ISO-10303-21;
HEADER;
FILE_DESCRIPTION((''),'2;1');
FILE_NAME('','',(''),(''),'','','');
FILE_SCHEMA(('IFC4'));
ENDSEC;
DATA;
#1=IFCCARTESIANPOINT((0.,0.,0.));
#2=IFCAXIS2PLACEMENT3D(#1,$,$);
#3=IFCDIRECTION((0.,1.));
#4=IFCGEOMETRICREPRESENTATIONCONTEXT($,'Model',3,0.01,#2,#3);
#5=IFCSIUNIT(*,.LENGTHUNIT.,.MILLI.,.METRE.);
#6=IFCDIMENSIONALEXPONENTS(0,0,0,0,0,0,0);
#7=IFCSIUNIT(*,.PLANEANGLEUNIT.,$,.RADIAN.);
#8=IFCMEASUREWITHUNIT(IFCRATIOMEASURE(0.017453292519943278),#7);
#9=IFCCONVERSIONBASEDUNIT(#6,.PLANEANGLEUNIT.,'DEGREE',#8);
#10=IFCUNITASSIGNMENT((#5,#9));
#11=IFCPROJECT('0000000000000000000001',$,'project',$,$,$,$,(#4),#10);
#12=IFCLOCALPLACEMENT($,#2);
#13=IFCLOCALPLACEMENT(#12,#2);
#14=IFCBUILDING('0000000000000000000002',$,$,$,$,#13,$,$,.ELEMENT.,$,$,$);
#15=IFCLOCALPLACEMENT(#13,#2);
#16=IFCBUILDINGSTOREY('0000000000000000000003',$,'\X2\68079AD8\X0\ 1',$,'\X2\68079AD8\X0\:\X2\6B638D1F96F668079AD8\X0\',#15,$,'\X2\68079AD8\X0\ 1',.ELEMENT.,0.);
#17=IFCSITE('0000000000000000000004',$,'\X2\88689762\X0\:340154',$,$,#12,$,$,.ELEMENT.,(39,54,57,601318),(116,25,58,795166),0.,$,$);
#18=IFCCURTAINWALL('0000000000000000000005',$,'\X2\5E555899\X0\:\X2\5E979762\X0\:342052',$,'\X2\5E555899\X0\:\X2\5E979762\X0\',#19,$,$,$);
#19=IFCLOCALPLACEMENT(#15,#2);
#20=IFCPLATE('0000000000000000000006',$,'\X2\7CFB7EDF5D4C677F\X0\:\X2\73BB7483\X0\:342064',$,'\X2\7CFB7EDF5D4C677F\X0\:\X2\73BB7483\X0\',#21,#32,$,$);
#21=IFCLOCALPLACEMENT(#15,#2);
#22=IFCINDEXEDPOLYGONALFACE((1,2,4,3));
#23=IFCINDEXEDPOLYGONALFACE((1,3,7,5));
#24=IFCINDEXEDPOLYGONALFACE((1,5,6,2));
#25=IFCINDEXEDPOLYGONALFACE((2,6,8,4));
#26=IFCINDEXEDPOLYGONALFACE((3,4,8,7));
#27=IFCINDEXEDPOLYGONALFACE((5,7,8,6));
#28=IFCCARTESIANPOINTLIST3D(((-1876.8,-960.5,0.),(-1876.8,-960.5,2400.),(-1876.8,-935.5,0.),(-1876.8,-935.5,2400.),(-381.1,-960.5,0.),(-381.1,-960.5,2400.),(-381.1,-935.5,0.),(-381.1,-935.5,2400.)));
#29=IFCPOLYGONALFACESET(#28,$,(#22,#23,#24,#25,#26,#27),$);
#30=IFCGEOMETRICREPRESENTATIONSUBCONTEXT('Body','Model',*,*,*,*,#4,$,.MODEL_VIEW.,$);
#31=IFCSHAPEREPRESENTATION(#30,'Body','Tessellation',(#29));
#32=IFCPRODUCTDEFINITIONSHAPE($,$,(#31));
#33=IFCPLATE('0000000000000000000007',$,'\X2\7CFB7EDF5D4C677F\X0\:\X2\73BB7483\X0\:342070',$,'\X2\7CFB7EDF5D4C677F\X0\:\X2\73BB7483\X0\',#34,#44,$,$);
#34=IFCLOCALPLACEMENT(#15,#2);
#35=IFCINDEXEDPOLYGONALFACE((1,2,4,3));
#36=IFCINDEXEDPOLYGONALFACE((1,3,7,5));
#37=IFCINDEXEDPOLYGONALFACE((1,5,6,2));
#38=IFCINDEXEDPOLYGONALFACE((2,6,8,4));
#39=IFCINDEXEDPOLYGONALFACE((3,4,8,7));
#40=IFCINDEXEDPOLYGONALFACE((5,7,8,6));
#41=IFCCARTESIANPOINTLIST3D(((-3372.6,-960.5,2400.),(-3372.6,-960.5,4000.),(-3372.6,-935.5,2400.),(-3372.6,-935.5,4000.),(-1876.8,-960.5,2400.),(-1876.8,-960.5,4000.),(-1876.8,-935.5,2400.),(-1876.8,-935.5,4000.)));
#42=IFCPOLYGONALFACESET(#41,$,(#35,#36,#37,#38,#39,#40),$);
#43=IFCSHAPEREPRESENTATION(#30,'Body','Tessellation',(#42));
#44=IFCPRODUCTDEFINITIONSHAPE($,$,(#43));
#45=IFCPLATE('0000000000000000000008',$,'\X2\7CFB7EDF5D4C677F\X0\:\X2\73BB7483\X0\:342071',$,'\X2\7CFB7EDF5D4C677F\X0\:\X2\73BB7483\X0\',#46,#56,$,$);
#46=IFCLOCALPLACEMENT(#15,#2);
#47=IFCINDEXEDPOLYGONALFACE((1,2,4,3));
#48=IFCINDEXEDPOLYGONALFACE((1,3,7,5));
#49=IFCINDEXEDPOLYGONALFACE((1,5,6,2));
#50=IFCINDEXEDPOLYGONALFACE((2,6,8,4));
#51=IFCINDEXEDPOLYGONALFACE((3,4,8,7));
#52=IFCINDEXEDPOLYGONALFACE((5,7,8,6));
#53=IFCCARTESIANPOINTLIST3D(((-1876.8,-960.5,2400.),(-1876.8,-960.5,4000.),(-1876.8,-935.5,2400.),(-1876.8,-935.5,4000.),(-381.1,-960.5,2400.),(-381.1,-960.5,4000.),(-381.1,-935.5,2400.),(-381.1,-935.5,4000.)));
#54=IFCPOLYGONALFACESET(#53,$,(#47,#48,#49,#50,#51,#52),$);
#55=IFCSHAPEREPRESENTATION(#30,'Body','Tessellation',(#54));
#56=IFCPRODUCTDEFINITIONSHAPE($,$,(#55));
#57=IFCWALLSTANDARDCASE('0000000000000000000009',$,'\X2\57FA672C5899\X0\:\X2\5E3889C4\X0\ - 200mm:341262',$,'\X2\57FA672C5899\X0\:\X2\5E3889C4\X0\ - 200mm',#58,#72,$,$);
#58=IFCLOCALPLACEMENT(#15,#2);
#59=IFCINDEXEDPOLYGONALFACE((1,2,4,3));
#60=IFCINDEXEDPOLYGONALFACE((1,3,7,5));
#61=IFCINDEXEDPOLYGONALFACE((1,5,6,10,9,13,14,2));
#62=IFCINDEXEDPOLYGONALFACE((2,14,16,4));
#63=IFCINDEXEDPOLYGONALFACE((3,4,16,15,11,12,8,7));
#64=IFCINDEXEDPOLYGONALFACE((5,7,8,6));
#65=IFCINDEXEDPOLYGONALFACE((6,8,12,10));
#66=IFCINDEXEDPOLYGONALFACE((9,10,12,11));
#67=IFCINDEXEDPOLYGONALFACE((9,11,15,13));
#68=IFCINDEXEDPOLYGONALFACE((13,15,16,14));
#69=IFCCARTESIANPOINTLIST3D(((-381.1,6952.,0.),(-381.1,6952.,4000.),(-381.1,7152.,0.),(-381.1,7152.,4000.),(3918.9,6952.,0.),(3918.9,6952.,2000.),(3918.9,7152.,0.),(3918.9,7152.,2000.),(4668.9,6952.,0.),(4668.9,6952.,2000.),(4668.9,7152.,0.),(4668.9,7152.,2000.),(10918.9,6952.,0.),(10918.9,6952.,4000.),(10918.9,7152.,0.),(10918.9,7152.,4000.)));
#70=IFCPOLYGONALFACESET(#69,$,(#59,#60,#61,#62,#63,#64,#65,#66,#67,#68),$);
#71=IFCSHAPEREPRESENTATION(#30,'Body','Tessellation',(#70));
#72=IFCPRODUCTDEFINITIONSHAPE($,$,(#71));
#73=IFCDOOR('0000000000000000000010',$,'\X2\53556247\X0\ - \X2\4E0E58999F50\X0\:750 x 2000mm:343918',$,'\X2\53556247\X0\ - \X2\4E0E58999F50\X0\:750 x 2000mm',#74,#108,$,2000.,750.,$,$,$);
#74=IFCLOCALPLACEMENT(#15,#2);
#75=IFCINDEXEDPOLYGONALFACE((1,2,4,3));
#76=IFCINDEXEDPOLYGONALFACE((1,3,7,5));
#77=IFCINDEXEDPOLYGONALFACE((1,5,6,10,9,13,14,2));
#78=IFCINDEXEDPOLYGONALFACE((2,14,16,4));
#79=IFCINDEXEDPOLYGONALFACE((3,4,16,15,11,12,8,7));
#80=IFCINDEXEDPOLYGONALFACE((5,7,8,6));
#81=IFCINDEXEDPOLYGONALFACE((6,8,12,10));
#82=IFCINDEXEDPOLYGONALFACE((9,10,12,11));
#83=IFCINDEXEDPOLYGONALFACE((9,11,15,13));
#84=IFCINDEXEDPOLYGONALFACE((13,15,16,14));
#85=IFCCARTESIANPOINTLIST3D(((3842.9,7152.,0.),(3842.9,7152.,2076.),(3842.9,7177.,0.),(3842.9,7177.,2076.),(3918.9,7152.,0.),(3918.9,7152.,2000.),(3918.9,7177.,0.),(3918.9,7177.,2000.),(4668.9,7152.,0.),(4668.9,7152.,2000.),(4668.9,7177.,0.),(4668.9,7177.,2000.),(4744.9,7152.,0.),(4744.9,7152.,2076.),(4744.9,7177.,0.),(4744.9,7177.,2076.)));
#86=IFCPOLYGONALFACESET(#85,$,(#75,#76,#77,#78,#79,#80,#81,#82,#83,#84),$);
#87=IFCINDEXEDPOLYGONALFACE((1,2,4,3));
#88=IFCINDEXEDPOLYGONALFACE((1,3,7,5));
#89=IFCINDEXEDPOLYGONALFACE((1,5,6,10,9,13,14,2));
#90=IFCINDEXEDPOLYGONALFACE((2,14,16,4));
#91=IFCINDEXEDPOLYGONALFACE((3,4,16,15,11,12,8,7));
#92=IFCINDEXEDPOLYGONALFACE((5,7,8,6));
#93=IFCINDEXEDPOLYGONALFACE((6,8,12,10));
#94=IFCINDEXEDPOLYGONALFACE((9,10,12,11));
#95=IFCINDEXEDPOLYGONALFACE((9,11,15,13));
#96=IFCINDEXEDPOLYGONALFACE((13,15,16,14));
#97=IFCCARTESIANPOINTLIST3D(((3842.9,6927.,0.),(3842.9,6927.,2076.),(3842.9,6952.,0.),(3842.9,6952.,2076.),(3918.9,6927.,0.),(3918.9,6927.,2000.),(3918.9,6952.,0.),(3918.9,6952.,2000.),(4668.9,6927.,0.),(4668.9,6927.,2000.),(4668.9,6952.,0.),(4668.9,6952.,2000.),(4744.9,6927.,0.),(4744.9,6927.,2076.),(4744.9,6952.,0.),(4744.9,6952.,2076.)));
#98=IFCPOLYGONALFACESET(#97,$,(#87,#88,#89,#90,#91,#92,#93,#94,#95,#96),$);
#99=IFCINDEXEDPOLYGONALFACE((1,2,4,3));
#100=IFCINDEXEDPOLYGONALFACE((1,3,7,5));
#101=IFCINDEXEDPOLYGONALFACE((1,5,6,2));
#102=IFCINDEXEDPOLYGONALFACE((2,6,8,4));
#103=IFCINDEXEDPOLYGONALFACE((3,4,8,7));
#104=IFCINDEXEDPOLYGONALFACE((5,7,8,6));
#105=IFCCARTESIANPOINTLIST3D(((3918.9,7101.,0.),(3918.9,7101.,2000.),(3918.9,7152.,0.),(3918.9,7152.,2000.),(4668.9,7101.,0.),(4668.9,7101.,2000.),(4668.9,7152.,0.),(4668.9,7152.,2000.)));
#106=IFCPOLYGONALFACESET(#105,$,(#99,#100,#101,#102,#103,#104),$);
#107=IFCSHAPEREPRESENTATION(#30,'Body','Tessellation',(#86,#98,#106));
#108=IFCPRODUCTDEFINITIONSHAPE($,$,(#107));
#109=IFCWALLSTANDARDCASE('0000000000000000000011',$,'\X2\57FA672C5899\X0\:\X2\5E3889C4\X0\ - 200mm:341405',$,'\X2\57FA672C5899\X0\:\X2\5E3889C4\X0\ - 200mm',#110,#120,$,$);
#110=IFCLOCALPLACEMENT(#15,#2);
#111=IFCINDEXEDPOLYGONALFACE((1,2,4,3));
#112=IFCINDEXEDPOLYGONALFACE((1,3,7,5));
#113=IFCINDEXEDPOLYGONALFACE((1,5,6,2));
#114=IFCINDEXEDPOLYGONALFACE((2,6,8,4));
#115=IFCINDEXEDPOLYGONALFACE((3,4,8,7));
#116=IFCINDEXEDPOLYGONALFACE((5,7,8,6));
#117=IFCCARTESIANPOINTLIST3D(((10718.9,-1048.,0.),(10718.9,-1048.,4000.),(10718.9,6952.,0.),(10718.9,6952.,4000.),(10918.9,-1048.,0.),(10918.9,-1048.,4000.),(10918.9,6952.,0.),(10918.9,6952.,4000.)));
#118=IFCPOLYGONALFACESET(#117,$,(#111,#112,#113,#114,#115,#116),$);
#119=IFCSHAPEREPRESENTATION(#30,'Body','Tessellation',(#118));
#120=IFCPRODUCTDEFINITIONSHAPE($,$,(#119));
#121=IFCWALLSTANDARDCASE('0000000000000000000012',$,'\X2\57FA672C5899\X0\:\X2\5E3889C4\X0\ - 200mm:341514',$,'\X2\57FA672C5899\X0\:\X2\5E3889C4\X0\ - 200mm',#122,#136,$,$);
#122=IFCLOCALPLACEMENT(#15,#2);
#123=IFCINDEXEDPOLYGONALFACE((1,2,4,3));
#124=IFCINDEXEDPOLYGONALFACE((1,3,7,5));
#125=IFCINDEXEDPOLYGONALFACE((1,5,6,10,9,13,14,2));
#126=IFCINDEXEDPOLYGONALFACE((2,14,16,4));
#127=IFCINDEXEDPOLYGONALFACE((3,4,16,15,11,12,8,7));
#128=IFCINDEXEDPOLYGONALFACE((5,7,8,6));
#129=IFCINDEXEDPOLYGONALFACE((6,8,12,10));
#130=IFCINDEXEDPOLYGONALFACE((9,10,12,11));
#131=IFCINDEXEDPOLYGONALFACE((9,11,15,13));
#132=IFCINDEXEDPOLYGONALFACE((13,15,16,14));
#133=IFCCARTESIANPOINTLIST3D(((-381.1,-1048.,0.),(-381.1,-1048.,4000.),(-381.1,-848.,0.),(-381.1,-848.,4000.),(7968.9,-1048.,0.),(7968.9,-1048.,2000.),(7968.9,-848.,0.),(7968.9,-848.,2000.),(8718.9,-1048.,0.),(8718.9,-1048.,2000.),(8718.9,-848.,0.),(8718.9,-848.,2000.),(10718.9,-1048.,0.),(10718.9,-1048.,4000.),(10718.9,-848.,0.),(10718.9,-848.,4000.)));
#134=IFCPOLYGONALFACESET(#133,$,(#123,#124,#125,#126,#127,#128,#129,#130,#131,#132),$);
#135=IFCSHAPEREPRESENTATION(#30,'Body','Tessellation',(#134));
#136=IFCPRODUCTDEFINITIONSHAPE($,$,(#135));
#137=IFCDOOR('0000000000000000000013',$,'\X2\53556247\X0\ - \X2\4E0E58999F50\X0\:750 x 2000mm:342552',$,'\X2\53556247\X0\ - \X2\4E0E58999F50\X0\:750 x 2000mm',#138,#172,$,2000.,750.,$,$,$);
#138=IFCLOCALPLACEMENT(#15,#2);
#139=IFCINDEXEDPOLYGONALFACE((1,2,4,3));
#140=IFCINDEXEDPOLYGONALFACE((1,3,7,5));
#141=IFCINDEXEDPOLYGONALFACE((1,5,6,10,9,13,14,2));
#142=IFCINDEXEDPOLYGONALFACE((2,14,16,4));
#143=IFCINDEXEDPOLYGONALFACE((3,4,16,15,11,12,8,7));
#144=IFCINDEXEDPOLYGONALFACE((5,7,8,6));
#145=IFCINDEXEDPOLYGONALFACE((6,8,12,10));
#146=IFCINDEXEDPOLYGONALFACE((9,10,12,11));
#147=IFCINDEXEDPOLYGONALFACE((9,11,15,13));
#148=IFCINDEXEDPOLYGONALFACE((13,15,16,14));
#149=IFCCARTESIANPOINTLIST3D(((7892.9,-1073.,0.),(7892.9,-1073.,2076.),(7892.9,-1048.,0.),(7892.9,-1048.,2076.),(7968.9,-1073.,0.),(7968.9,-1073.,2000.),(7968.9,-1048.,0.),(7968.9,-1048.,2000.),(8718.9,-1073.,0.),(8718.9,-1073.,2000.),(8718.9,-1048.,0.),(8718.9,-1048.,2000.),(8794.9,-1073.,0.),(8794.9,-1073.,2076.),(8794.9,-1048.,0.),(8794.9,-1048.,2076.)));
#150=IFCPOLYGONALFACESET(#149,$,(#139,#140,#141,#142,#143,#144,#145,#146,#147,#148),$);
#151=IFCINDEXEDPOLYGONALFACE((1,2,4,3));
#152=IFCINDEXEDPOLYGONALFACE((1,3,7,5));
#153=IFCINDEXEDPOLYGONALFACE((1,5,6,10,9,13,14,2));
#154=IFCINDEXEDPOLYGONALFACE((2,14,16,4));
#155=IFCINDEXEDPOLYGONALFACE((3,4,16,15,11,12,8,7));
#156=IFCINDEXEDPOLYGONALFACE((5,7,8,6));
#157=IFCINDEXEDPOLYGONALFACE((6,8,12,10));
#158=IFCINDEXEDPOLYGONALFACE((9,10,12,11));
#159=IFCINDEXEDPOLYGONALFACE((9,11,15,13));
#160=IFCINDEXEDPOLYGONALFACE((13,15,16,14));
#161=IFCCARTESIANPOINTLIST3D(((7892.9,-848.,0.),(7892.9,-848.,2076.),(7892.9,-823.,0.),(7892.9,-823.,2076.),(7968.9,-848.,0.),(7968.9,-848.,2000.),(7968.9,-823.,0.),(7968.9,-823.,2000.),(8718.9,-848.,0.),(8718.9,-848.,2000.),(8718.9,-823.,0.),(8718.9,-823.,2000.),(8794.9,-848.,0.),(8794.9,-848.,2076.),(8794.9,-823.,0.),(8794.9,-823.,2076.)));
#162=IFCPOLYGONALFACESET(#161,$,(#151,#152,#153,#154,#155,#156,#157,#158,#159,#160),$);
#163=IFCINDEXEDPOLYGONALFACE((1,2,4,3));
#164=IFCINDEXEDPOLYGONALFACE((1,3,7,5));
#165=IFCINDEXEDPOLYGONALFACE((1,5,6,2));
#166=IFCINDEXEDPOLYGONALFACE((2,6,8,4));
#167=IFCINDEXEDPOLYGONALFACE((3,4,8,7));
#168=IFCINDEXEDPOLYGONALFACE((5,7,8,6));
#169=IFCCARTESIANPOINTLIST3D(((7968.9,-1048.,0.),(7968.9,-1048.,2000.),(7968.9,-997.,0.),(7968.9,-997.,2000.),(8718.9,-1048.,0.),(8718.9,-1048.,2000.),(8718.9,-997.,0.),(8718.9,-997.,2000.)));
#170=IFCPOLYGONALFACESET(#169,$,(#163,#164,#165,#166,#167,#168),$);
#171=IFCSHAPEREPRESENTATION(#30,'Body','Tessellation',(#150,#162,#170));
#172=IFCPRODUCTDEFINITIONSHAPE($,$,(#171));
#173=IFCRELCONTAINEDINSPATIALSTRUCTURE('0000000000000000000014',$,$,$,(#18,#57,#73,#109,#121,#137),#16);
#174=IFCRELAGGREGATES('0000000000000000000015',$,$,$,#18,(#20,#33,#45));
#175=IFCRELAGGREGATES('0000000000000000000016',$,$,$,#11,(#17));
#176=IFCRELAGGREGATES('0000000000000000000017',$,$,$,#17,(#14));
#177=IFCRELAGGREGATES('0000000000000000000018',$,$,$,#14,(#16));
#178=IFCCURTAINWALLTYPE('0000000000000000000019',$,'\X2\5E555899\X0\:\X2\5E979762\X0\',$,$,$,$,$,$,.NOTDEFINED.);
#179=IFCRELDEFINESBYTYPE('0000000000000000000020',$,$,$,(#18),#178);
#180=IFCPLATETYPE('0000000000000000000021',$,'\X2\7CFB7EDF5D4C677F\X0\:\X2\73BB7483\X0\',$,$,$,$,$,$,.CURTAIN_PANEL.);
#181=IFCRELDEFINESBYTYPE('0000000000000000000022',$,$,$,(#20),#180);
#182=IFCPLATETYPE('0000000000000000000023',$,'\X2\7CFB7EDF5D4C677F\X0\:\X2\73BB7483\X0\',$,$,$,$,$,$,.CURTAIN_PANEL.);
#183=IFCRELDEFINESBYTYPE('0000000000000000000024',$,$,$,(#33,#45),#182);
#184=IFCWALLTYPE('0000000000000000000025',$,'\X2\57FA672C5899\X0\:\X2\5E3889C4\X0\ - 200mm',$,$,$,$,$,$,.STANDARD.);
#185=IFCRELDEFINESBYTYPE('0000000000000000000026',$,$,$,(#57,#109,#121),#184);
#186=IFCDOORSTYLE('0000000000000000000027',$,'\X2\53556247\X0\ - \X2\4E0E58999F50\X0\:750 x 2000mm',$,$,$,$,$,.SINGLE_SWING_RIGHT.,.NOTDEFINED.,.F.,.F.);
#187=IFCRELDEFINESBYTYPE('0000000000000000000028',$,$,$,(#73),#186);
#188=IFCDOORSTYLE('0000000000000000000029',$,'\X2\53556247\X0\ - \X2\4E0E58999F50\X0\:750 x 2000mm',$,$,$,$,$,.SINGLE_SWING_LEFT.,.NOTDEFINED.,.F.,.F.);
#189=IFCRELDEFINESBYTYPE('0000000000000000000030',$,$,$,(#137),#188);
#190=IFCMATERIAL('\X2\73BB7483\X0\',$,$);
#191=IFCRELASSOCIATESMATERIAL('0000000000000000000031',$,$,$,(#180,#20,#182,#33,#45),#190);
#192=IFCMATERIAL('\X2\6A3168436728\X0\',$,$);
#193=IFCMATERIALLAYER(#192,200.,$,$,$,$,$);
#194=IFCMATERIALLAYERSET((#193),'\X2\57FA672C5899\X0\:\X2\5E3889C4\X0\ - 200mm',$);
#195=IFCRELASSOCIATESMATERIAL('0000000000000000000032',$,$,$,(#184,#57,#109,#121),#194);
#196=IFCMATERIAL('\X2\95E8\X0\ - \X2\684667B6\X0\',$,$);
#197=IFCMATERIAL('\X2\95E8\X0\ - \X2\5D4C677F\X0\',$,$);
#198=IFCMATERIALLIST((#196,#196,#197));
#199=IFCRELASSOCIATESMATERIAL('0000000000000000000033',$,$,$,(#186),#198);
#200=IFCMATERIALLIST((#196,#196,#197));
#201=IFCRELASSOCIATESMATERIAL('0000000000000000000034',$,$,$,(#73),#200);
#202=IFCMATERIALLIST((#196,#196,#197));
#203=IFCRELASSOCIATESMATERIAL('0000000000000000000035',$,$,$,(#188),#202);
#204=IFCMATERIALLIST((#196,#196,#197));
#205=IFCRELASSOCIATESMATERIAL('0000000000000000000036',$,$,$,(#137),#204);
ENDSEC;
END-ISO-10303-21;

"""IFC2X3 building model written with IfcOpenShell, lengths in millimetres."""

from ifc_helpers import new_model, entity, si_unit, converted_unit, direction, frame, frame_2d, origin, origin_2d_with_axis, place, context, subcontext, project, spatial, polyline, rectangle, outline, extrude, source, transform, mapped, material, material_list, layer, layer_set, layer_usage, type_object, type_shapes, element, fill, aggregate, save


model = new_model("IFC2X3")

# Units and contexts
model_context = context("Model", 3, precision=0.01, world=origin(), true_north=direction((0.0, 1.0)))
body_context = subcontext(model_context, "Body", "Model", "MODEL_VIEW")
ifc_project = project(units=[si_unit("LENGTHUNIT", "METRE", prefix="MILLI"), converted_unit("PLANEANGLEUNIT", "DEGREE", entity("IfcRatioMeasure", 0.017453292519943278), si_unit("PLANEANGLEUNIT", "RADIAN"), dimensions=[0, 0, 0, 0, 0, 0, 0])], contexts=[model_context])

# Site, building, storey
site_placement = place(None, origin())
site = spatial("IfcSite", under=ifc_project, at=site_placement, Name="表面:340154", CompositionType="ELEMENT", RefLatitude=(39, 54, 57, 601318), RefLongitude=(116, 25, 58, 795166), RefElevation=0.0)
building_placement = place(site_placement, origin())
building = spatial("IfcBuilding", under=site, at=building_placement, CompositionType="ELEMENT")
storey_placement = place(building_placement, origin())
storey = spatial("IfcBuildingStorey", under=building, at=storey_placement, Name="标高 1", ObjectType="标高:正负零标高", LongName="标高 1", CompositionType="ELEMENT", Elevation=0.0)

# Shared definitions
curtain_wall_type = type_object("IfcCurtainWallType", Name="幕墙:店面", PredefinedType="NOTDEFINED")
ifc_material_1 = material(Name="玻璃")

# Curtain wall, plates
curtain_wall_1_placement = place(storey_placement, origin())
curtain_wall_1 = element("IfcCurtainWall", 1, at=curtain_wall_1_placement, inside=storey, type_object=curtain_wall_type, Name="幕墙:店面:342052", ObjectType="幕墙:店面")
plate_type_1 = type_object("IfcPlateType", Name="系统嵌板:玻璃", PredefinedType="CURTAIN_PANEL", material=ifc_material_1)
shared_shape_1 = source(origin(), body_context, "Body", "SweptSolid", [
    extrude(rectangle(XDim=25.0, YDim=1495.8, at=origin_2d_with_axis()), frame((0.0, 0.0, 0.0), z_axis=(0.0, 0.0, 1.0), x_axis=(0.0, 1.0, 0.0)), (0.0, 0.0, 1.0), 2400.0),
])
type_shapes(plate_type_1, [shared_shape_1])
plate_1_placement = place(curtain_wall_1_placement, frame((-1129.0, -948.0, 0.0)))
plate_1 = element("IfcPlate", 2, at=plate_1_placement, type_object=plate_type_1, material=ifc_material_1, Name="系统嵌板:玻璃:342064", ObjectType="系统嵌板:玻璃", context=body_context, shape_type="MappedRepresentation", body=[
    mapped(shared_shape_1, transform((0.0, 0.0, 0.0), scale=1.0)),
])
plate_type_2 = type_object("IfcPlateType", Name="系统嵌板:玻璃", PredefinedType="CURTAIN_PANEL", material=ifc_material_1)
shared_shape_2 = source(origin(), body_context, "Body", "SweptSolid", [
    extrude(rectangle(XDim=25.0, YDim=1495.8, at=origin_2d_with_axis()), frame((0.0, 0.0, 0.0), z_axis=(0.0, 0.0, 1.0), x_axis=(0.0, 1.0, 0.0)), (0.0, 0.0, 1.0), 1600.0),
])
type_shapes(plate_type_2, [shared_shape_2])
plate_2_placement = place(curtain_wall_1_placement, frame((-2624.7, -948.0, 2400.0)))
plate_2 = element("IfcPlate", 3, at=plate_2_placement, type_object=plate_type_2, material=ifc_material_1, Name="系统嵌板:玻璃:342070", ObjectType="系统嵌板:玻璃", context=body_context, shape_type="MappedRepresentation", body=[
    mapped(shared_shape_2, transform((0.0, 0.0, 0.0), scale=1.0)),
])
plate_3_placement = place(curtain_wall_1_placement, frame((-1129.0, -948.0, 2400.0)))
plate_3 = element("IfcPlate", 4, at=plate_3_placement, type_object=plate_type_2, material=ifc_material_1, Name="系统嵌板:玻璃:342071", ObjectType="系统嵌板:玻璃", context=body_context, shape_type="MappedRepresentation", body=[
    mapped(shared_shape_2, transform((0.0, 0.0, 0.0), scale=1.0)),
])
aggregate(curtain_wall_1, [plate_1, plate_2, plate_3])

# Wall, opening, door
ifc_material_2 = material(Name="樱桃木")
ifc_layer_1 = layer(ifc_material_2, 200.0)
ifc_layer_set_1 = layer_set([ifc_layer_1], Name="基本墙:常规 - 200mm")
ifc_layer_usage_1 = layer_usage(ifc_layer_set_1, "AXIS2", "NEGATIVE", 100.0)
wall_type_1 = type_object("IfcWallType", Name="基本墙:常规 - 200mm", PredefinedType="STANDARD", material=ifc_layer_set_1)
wall_1_placement = place(storey_placement, frame((-381.1, 7052.0, 0.0)))
wall_1 = element("IfcWallStandardCase", 5, at=wall_1_placement, inside=storey, type_object=wall_type_1, material=ifc_layer_usage_1, Name="基本墙:常规 - 200mm:341262", ObjectType="基本墙:常规 - 200mm", context=body_context, shape_type="SweptSolid", body=[
    extrude(rectangle(XDim=11300.0, YDim=200.0, at=frame_2d((5650.0, 0.0), x_axis=(1.0, 0.0))), origin(), (0.0, 0.0, 1.0), 4000.0),
])
opening_1_placement = place(wall_1_placement, frame((4300.0, -100.0, 0.0)))
opening_1 = element("IfcOpeningElement", 6, at=opening_1_placement, cuts=wall_1, ObjectType="Opening", context=body_context, shape_type="SweptSolid", body=[
    extrude(rectangle(XDim=750.0, YDim=2000.0, at=frame_2d((1000.0, 375.0), x_axis=(0.0, 1.0))), frame((0.0, 0.0, 0.0), z_axis=(0.0, 1.0, 0.0), x_axis=(0.0, 0.0, 1.0)), (0.0, 0.0, 1.0), 200.0),
])
ifc_material_3 = material(Name="门 - 框架")
ifc_material_4 = material(Name="门 - 嵌板")
ifc_material_list_1 = material_list([ifc_material_3, ifc_material_3, ifc_material_4])
ifc_material_list_2 = material_list([ifc_material_3, ifc_material_3, ifc_material_4])
door_style_1 = type_object("IfcDoorStyle", Name="单扇 - 与墙齐:750 x 2000mm", ConstructionType="NOTDEFINED", OperationType="SINGLE_SWING_RIGHT", ParameterTakesPrecedence=False, Sizeable=False, material=ifc_material_list_2)
shared_shape_3 = source(origin(), body_context, "Body", "SweptSolid", [
    extrude(outline(polyline([(-451.0, -1057.0), (451.0, -1057.0), (451.0, 1019.0), (375.0, 1019.0), (375.0, -981.0), (-375.0, -981.0), (-375.0, 1019.0), (-451.0, 1019.0), (-451.0, -1057.0)])), frame((375.0, 200.0, 1019.0), z_axis=(0.0, 1.0, 0.0), x_axis=(1.0, 0.0, 0.0)), (0.0, 0.0, 1.0), 25.0),
    extrude(outline(polyline([(-1057.0, -451.0), (1019.0, -451.0), (1019.0, -375.0), (-981.0, -375.0), (-981.0, 375.0), (1019.0, 375.0), (1019.0, 451.0), (-1057.0, 451.0), (-1057.0, -451.0)])), frame((375.0, -25.0, 1019.0), z_axis=(0.0, 1.0, 0.0), x_axis=(0.0, 0.0, -1.0)), (0.0, 0.0, 1.0), 25.0),
    extrude(rectangle(XDim=51.0, YDim=750.0, at=frame_2d((0.0, 0.0), x_axis=(1.0, 0.0))), frame((375.0, 174.5, 0.0), z_axis=(0.0, 0.0, 1.0), x_axis=(0.0, 1.0, 0.0)), (0.0, 0.0, 1.0), 2000.0),
])
type_shapes(door_style_1, [shared_shape_3])
door_1_placement = place(opening_1_placement, origin())
door_1 = element("IfcDoor", 7, at=door_1_placement, inside=storey, type_object=door_style_1, material=ifc_material_list_1, Name="单扇 - 与墙齐:750 x 2000mm:343918", ObjectType="单扇 - 与墙齐:750 x 2000mm", OverallHeight=2000.0, OverallWidth=750.0, context=body_context, shape_type="MappedRepresentation", body=[
    mapped(shared_shape_3, transform((0.0, 0.0, 0.0), scale=1.0)),
])
fill(opening_1, door_1)

# Wall
ifc_layer_usage_2 = layer_usage(ifc_layer_set_1, "AXIS2", "NEGATIVE", 100.0)
wall_2_placement = place(storey_placement, frame((10818.9, 6952.0, 0.0), z_axis=(0.0, 0.0, 1.0), x_axis=(0.0, -1.0, 0.0)))
element("IfcWallStandardCase", 8, at=wall_2_placement, inside=storey, type_object=wall_type_1, material=ifc_layer_usage_2, Name="基本墙:常规 - 200mm:341405", ObjectType="基本墙:常规 - 200mm", context=body_context, shape_type="SweptSolid", body=[
    extrude(rectangle(XDim=8000.0, YDim=200.0, at=frame_2d((4000.0, 0.0), x_axis=(-1.0, 0.0))), origin(), (0.0, 0.0, 1.0), 4000.0),
])

# Wall, opening, door
ifc_layer_usage_3 = layer_usage(ifc_layer_set_1, "AXIS2", "NEGATIVE", 100.0)
wall_3_placement = place(storey_placement, frame((10718.9, -948.0, 0.0), z_axis=(0.0, 0.0, 1.0), x_axis=(-1.0, 0.0, 0.0)))
wall_3 = element("IfcWallStandardCase", 9, at=wall_3_placement, inside=storey, type_object=wall_type_1, material=ifc_layer_usage_3, Name="基本墙:常规 - 200mm:341514", ObjectType="基本墙:常规 - 200mm", context=body_context, shape_type="SweptSolid", body=[
    extrude(rectangle(XDim=11100.0, YDim=200.0, at=frame_2d((5550.0, 0.0), x_axis=(1.0, 0.0))), origin(), (0.0, 0.0, 1.0), 4000.0),
])
opening_2_placement = place(wall_3_placement, frame((2000.0, -100.0, 0.0)))
opening_2 = element("IfcOpeningElement", 10, at=opening_2_placement, cuts=wall_3, ObjectType="Opening", context=body_context, shape_type="SweptSolid", body=[
    extrude(rectangle(XDim=750.0, YDim=2000.0, at=frame_2d((1000.0, 375.0), x_axis=(0.0, -1.0))), frame((0.0, 0.0, 0.0), z_axis=(0.0, 1.0, 0.0), x_axis=(0.0, 0.0, 1.0)), (0.0, 0.0, 1.0), 200.0),
])
ifc_material_list_3 = material_list([ifc_material_3, ifc_material_3, ifc_material_4])
ifc_material_list_4 = material_list([ifc_material_3, ifc_material_3, ifc_material_4])
door_style_2 = type_object("IfcDoorStyle", Name="单扇 - 与墙齐:750 x 2000mm", ConstructionType="NOTDEFINED", OperationType="SINGLE_SWING_LEFT", ParameterTakesPrecedence=False, Sizeable=False, material=ifc_material_list_4)
shared_shape_4 = source(origin(), body_context, "Body", "SweptSolid", [
    extrude(outline(polyline([(-451.0, -1057.0), (451.0, -1057.0), (451.0, 1019.0), (375.0, 1019.0), (375.0, -981.0), (-375.0, -981.0), (-375.0, 1019.0), (-451.0, 1019.0), (-451.0, -1057.0)])), frame((375.0, 225.0, 1019.0), z_axis=(0.0, -1.0, 0.0), x_axis=(-1.0, 0.0, 0.0)), (0.0, 0.0, 1.0), 25.0),
    extrude(outline(polyline([(-1057.0, -451.0), (1019.0, -451.0), (1019.0, -375.0), (-981.0, -375.0), (-981.0, 375.0), (1019.0, 375.0), (1019.0, 451.0), (-1057.0, 451.0), (-1057.0, -451.0)])), frame((375.0, 0.0, 1019.0), z_axis=(0.0, -1.0, 0.0), x_axis=(0.0, 0.0, -1.0)), (0.0, 0.0, 1.0), 25.0),
    extrude(rectangle(XDim=750.0, YDim=51.0, at=frame_2d((0.0, 0.0), x_axis=(1.0, 0.0))), frame((375.0, 174.5, 0.0)), (0.0, 0.0, 1.0), 2000.0),
])
type_shapes(door_style_2, [shared_shape_4])
door_2_placement = place(opening_2_placement, origin())
door_2 = element("IfcDoor", 11, at=door_2_placement, inside=storey, type_object=door_style_2, material=ifc_material_list_3, Name="单扇 - 与墙齐:750 x 2000mm:342552", ObjectType="单扇 - 与墙齐:750 x 2000mm", OverallHeight=2000.0, OverallWidth=750.0, context=body_context, shape_type="MappedRepresentation", body=[
    mapped(shared_shape_4, transform((0.0, 0.0, 0.0), scale=1.0)),
])
fill(opening_2, door_2)

save(model, "model.ifc")
